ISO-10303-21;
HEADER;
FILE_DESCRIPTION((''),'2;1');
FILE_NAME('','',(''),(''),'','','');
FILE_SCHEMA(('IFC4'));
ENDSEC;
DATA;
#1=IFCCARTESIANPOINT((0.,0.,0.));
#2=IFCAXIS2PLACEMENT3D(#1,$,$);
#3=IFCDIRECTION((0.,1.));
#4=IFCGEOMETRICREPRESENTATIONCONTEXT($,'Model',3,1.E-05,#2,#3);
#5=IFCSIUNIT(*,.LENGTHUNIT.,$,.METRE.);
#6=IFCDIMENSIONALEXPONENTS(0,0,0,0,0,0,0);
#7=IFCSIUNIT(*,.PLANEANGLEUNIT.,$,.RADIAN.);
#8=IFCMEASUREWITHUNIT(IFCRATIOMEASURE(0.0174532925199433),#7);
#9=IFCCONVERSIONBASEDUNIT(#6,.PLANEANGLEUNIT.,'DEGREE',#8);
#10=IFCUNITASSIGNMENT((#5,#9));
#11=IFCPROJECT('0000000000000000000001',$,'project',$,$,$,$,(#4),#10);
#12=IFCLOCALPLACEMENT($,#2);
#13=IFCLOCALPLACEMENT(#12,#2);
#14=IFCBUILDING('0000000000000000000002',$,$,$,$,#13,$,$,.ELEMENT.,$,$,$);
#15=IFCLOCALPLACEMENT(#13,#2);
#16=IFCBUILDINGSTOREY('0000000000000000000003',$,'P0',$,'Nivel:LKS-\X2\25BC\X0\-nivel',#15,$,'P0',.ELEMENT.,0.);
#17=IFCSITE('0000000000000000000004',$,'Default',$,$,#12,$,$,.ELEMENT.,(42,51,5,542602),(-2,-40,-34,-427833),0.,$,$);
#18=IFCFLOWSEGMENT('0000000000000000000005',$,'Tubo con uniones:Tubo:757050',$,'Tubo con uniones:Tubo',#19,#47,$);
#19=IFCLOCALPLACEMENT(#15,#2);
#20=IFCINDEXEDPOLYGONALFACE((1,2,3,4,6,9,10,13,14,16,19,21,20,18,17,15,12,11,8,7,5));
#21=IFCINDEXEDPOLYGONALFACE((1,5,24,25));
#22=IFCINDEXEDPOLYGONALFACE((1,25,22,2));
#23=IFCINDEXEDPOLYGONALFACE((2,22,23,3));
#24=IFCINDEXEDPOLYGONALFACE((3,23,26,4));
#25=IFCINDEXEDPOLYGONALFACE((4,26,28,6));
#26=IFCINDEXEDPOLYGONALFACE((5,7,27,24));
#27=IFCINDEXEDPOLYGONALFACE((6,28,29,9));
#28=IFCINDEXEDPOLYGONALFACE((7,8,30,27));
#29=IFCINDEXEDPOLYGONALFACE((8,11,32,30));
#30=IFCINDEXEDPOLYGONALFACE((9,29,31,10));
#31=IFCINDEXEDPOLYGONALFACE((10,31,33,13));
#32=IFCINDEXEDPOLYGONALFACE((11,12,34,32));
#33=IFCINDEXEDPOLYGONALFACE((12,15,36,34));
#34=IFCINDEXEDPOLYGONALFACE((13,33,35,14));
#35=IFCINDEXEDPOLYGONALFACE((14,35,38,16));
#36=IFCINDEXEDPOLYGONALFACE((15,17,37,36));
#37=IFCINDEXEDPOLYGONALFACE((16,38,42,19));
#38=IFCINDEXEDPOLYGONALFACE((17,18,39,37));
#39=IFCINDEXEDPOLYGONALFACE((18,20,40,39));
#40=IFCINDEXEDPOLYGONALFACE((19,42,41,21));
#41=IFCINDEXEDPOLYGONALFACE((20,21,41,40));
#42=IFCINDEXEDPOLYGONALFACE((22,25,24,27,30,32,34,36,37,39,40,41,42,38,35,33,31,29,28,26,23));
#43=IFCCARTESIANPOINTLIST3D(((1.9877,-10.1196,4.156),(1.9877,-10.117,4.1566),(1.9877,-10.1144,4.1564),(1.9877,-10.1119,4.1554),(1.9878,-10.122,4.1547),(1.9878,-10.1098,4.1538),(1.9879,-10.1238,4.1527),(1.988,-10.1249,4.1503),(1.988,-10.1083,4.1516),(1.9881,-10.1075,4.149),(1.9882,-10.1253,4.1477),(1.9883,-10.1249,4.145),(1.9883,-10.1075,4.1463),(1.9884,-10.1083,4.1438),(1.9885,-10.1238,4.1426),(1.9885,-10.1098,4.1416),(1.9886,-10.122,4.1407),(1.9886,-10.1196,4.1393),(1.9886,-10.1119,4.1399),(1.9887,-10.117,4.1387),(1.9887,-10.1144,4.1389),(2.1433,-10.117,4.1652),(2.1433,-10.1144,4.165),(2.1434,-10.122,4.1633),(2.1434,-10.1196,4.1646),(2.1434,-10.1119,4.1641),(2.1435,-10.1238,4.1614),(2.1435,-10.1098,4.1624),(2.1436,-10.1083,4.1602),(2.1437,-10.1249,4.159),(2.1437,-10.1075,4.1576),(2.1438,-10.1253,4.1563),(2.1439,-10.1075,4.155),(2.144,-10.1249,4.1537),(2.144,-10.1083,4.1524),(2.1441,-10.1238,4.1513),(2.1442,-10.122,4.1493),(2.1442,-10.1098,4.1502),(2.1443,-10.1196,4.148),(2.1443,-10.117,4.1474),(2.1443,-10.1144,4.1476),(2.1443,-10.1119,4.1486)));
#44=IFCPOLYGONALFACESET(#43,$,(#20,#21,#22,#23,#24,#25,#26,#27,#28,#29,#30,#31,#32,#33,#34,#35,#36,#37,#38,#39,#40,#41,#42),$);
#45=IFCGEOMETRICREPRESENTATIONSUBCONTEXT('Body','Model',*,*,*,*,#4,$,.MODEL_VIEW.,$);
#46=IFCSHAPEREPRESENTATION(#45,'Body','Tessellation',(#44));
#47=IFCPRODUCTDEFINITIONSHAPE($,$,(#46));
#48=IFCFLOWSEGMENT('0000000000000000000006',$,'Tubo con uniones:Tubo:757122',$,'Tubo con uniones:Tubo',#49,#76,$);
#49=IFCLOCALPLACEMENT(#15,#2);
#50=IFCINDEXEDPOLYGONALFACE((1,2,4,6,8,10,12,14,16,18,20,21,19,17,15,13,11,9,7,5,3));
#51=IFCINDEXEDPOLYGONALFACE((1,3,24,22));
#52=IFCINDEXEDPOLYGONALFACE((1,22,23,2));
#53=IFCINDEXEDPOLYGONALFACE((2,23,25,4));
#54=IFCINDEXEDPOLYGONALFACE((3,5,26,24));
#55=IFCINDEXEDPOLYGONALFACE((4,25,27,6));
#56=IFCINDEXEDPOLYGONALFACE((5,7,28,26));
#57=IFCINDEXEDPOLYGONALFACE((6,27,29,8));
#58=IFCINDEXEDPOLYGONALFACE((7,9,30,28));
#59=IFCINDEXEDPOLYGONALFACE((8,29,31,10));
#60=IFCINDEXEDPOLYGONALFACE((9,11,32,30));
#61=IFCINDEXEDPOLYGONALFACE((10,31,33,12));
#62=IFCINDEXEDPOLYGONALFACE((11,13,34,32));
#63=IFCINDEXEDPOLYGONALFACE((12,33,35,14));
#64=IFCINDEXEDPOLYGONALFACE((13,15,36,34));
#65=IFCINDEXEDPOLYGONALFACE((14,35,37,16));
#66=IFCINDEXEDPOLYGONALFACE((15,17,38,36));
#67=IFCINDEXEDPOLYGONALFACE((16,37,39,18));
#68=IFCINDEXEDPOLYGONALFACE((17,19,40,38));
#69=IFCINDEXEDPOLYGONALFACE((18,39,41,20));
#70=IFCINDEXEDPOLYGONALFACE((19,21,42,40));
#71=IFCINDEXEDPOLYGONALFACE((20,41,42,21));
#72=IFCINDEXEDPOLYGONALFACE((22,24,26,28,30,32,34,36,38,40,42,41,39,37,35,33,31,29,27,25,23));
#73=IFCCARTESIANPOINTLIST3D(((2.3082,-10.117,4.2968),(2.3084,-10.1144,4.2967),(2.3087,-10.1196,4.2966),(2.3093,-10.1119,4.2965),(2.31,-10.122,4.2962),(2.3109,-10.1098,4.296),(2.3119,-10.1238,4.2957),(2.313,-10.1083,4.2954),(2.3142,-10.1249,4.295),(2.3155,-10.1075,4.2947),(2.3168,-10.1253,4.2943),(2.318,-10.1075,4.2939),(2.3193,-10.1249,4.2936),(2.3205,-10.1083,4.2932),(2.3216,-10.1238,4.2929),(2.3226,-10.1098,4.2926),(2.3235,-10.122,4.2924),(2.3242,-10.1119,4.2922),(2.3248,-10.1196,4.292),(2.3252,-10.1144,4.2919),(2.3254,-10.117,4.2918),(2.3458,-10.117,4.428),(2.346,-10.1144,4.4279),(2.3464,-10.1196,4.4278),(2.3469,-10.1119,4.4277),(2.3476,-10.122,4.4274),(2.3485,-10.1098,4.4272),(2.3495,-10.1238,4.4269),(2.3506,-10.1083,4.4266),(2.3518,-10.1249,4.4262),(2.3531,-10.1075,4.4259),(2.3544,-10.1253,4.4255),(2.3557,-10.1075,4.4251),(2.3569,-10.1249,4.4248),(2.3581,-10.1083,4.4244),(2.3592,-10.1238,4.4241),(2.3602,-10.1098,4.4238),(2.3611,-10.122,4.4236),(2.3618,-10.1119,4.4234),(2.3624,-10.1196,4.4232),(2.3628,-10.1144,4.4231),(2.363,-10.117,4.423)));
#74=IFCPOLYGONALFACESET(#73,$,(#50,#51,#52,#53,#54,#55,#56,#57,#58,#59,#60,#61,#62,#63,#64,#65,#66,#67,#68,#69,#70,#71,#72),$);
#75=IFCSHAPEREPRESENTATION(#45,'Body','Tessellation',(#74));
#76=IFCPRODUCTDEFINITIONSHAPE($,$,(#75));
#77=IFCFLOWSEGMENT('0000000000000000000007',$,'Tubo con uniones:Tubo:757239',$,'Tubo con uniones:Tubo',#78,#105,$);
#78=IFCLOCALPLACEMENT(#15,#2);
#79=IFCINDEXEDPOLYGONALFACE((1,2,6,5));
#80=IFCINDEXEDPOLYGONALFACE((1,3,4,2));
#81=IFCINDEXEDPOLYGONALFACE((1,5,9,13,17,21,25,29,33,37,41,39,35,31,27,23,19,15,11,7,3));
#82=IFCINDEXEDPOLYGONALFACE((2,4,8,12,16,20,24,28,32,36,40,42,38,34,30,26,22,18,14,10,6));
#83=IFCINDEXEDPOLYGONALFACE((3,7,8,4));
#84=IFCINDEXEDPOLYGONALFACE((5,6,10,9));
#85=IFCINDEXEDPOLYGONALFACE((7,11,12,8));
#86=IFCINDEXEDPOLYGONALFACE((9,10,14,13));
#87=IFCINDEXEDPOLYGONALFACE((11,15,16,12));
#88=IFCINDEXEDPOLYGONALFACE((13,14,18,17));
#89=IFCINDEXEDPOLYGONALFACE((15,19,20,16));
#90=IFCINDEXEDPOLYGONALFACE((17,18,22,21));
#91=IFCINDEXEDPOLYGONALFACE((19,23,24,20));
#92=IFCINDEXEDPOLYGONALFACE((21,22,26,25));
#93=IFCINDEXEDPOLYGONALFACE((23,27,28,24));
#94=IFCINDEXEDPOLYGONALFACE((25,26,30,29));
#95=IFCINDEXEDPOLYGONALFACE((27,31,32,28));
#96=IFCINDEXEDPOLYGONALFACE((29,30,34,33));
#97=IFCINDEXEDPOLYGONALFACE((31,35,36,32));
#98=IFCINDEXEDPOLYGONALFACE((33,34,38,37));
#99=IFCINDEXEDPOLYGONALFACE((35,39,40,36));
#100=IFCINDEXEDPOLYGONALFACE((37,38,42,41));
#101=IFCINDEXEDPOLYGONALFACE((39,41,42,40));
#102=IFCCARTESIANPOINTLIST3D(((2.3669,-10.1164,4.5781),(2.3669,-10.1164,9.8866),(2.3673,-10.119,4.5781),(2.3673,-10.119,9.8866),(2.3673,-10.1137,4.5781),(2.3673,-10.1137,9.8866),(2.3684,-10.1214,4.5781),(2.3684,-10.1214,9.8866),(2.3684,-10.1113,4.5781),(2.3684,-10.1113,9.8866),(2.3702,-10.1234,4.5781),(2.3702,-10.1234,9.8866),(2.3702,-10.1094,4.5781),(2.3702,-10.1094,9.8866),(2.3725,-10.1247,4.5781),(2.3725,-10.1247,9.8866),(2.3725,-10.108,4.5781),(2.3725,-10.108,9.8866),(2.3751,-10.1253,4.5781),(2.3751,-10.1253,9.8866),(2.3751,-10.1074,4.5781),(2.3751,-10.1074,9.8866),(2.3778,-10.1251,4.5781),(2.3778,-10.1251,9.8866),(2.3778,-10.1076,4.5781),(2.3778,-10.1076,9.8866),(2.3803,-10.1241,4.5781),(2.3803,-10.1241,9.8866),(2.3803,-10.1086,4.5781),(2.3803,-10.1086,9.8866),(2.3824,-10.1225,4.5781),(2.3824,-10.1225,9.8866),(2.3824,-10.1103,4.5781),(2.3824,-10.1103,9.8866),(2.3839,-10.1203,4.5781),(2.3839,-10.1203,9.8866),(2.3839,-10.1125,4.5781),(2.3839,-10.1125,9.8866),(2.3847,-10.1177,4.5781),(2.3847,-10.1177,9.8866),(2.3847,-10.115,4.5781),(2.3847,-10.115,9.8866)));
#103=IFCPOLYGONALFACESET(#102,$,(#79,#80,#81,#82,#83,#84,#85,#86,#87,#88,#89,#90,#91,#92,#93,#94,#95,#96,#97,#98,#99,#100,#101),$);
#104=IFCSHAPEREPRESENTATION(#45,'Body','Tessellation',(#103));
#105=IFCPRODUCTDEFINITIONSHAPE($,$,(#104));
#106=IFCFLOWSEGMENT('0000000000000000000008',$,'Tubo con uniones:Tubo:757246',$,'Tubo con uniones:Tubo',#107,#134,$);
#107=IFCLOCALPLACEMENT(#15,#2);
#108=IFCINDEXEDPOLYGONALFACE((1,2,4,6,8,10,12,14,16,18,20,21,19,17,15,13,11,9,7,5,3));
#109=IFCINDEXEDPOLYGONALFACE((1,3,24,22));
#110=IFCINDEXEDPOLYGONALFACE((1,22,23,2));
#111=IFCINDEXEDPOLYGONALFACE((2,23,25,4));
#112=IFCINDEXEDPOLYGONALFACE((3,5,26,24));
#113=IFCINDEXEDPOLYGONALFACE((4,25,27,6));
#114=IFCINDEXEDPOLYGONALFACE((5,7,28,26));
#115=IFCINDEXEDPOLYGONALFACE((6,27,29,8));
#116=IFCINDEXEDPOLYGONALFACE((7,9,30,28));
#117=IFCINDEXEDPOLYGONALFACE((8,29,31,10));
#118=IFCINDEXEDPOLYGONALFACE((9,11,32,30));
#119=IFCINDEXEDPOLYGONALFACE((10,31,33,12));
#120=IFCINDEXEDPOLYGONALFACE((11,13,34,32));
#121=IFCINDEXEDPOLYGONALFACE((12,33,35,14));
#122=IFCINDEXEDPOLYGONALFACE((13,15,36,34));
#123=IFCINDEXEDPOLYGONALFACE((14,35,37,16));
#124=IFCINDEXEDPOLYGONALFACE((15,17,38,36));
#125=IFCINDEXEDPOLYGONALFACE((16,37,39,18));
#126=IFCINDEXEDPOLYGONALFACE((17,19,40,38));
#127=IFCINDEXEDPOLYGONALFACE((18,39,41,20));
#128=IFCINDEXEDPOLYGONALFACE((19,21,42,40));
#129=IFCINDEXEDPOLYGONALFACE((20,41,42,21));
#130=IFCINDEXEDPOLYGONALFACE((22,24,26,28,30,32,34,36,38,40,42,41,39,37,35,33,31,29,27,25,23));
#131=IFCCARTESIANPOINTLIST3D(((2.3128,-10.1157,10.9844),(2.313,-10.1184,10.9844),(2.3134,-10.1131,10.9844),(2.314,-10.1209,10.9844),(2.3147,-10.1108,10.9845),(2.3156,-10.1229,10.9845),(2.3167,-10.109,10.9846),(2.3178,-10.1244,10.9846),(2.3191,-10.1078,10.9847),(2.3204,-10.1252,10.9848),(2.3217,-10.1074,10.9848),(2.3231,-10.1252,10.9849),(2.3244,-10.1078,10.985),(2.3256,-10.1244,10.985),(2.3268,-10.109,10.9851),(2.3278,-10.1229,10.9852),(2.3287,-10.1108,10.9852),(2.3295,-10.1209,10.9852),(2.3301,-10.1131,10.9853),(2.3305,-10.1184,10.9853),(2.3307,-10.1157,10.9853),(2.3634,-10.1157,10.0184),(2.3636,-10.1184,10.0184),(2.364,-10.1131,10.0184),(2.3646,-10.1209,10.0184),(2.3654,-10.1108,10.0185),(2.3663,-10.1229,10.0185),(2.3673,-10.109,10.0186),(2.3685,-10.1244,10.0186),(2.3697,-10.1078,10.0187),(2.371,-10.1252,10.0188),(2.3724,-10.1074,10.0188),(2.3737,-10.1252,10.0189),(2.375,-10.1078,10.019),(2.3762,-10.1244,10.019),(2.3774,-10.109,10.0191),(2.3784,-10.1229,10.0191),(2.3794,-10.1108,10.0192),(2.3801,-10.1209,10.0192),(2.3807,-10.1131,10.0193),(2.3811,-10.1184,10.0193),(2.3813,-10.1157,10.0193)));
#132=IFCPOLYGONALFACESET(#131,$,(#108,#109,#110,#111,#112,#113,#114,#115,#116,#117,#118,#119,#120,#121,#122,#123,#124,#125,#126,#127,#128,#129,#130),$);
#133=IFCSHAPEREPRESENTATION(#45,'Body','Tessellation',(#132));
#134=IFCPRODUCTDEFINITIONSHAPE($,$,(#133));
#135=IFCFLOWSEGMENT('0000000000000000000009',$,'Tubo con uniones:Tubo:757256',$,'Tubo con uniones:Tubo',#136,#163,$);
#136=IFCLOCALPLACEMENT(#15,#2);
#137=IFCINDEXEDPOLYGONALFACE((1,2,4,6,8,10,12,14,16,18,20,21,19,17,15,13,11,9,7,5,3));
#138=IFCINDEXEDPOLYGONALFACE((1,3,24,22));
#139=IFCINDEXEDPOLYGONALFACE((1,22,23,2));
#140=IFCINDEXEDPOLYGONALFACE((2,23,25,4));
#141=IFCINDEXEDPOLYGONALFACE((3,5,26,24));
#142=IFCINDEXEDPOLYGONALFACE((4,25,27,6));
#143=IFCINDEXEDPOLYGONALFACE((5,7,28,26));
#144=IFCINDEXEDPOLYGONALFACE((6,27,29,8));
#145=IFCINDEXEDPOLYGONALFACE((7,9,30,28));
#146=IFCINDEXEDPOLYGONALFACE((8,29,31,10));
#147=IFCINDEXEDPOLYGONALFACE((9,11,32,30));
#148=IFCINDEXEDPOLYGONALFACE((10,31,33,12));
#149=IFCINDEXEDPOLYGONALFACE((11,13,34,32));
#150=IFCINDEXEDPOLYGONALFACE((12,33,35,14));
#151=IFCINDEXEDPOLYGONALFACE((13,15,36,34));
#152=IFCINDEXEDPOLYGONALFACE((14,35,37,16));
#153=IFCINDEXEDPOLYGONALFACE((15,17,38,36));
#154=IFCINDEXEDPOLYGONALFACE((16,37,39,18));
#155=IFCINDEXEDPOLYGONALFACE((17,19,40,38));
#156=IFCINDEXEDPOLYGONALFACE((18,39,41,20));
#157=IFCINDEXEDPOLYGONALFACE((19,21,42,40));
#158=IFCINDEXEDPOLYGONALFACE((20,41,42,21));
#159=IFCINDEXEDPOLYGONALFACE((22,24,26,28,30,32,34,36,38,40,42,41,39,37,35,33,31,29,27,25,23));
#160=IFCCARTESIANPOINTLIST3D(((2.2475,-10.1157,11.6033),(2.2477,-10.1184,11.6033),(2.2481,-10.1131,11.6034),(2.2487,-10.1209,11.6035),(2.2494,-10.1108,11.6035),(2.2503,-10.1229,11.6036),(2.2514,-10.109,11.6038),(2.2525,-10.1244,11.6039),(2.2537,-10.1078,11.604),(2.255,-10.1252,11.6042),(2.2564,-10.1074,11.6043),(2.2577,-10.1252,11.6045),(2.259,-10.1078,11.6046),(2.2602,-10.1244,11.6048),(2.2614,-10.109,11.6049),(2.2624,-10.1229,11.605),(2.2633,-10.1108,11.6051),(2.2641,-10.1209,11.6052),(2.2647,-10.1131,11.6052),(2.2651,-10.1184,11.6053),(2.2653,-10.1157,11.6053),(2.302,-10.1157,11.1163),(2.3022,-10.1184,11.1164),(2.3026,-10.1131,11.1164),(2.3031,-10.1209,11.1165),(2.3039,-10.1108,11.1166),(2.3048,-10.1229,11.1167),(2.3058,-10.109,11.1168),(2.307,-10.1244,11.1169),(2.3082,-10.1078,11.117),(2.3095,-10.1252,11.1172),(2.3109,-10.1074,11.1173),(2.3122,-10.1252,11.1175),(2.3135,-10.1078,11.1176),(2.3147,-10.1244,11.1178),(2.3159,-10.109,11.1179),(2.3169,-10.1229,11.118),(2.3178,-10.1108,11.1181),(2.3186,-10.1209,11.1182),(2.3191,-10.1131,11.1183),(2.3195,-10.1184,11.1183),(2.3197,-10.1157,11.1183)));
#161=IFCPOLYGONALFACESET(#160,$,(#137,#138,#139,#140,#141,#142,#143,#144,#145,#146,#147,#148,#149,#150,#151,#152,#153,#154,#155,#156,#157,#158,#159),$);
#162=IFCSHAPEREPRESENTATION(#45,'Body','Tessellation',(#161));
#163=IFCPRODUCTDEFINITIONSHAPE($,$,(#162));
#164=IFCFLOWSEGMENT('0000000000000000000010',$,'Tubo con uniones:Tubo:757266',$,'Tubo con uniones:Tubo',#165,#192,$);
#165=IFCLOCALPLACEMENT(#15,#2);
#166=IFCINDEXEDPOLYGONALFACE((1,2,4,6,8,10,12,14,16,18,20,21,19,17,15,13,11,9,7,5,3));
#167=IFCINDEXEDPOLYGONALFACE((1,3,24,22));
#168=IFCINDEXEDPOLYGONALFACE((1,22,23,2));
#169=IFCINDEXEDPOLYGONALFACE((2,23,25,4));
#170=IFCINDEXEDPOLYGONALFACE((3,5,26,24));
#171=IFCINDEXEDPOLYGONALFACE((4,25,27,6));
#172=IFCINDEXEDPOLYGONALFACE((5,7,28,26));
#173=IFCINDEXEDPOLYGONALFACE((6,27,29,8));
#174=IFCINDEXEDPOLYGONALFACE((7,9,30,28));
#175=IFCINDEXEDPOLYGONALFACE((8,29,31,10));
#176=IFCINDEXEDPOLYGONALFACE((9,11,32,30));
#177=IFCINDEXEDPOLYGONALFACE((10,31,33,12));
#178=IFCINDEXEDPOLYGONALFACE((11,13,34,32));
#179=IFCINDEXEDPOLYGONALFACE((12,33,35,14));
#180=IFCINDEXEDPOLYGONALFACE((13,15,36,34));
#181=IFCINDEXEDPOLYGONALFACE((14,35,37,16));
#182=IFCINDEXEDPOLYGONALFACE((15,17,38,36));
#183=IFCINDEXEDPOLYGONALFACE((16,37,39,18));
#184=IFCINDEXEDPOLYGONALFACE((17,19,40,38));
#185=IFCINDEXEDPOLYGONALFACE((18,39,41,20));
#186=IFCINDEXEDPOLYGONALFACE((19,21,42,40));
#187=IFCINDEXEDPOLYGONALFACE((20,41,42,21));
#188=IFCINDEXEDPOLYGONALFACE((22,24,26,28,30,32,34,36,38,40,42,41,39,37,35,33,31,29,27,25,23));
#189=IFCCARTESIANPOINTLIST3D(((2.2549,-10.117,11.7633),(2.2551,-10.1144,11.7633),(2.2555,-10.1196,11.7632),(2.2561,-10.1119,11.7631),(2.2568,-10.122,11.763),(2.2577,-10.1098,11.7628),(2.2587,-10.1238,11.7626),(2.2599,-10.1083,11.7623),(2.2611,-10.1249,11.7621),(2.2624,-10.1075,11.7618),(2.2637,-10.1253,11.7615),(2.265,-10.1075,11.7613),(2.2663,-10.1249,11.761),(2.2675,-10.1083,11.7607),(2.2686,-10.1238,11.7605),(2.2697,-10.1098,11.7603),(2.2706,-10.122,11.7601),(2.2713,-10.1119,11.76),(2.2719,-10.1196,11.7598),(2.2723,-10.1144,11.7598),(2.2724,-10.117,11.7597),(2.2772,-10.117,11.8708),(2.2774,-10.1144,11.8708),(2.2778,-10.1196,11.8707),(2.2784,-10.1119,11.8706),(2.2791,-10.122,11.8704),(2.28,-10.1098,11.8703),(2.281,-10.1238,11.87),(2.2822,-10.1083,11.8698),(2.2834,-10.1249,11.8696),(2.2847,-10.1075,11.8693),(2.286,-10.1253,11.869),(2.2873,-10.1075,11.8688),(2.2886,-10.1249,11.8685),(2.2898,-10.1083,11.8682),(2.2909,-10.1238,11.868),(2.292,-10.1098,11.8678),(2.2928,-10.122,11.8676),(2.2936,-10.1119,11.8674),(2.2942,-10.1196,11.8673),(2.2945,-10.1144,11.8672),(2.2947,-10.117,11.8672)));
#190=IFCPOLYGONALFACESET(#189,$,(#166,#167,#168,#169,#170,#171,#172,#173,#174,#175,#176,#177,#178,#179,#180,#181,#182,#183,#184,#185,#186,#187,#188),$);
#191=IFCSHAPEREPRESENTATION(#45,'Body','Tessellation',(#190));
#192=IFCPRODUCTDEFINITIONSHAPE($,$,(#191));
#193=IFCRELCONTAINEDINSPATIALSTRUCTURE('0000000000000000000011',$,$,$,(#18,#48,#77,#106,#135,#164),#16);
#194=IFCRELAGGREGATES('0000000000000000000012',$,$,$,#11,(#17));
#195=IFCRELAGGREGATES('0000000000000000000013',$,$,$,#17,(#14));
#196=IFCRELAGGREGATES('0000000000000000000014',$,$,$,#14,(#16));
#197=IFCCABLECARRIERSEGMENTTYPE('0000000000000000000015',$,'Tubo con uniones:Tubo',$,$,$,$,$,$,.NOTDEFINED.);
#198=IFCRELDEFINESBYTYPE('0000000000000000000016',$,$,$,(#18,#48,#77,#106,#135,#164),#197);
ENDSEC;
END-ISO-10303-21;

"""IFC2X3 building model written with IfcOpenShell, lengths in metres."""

from ifc_helpers import new_model, entity, si_unit, converted_unit, direction, frame, frame_2d, origin, origin_2d_with_axis, place, context, subcontext, project, spatial, circle, extrude, type_object, element, save


model = new_model("IFC2X3")

# Units and contexts
model_context = context("Model", 3, precision=1e-05, world=origin(), true_north=direction((0.0, 1.0)))
body_context = subcontext(model_context, "Body", "Model", "MODEL_VIEW")
ifc_project = project(units=[si_unit("LENGTHUNIT", "METRE"), converted_unit("PLANEANGLEUNIT", "DEGREE", entity("IfcRatioMeasure", 0.0174532925199433), si_unit("PLANEANGLEUNIT", "RADIAN"), dimensions=[0, 0, 0, 0, 0, 0, 0])], contexts=[model_context])

# Site, building, storey
site_placement = place(None, origin())
site = spatial("IfcSite", under=ifc_project, at=site_placement, Name="Default", CompositionType="ELEMENT", RefLatitude=(42, 51, 5, 542602), RefLongitude=(-2, -40, -34, -427833), RefElevation=0.0)
building_placement = place(site_placement, origin())
building = spatial("IfcBuilding", under=site, at=building_placement, CompositionType="ELEMENT")
storey_placement = place(building_placement, origin())
storey = spatial("IfcBuildingStorey", under=building, at=storey_placement, Name="P0", ObjectType="Nivel:LKS-▼-nivel", LongName="P0", CompositionType="ELEMENT", Elevation=0.0)

# Flow segments
cable_carrier_segment_type = type_object("IfcCableCarrierSegmentType", Name="Tubo con uniones:Tubo", PredefinedType="NOTDEFINED")
flow_segment_1_placement = place(storey_placement, origin())
element("IfcFlowSegment", 1, at=flow_segment_1_placement, inside=storey, type_object=cable_carrier_segment_type, Name="Tubo con uniones:Tubo:757050", ObjectType="Tubo con uniones:Tubo", context=body_context, shape_type="SweptSolid", body=[
    extrude(circle(Radius=0.009, at=origin_2d_with_axis()), frame((1.9882, -10.1164, 4.1477), z_axis=(0.998462, 0.0, 0.055441), x_axis=(0.0, -1.0, 0.0)), (0.0, 0.0, 1.0), 0.1559),
])
flow_segment_2_placement = place(storey_placement, origin())
element("IfcFlowSegment", 2, at=flow_segment_2_placement, inside=storey, type_object=cable_carrier_segment_type, Name="Tubo con uniones:Tubo:757122", ObjectType="Tubo con uniones:Tubo", context=body_context, shape_type="SweptSolid", body=[
    extrude(circle(Radius=0.009, at=origin_2d_with_axis()), frame((2.3168, -10.1164, 4.2943), z_axis=(0.275637, 0.0, 0.961262), x_axis=(0.0, -1.0, 0.0)), (0.0, 0.0, 1.0), 0.1365),
])
flow_segment_3_placement = place(storey_placement, origin())
element("IfcFlowSegment", 3, at=flow_segment_3_placement, inside=storey, type_object=cable_carrier_segment_type, Name="Tubo con uniones:Tubo:757239", ObjectType="Tubo con uniones:Tubo", context=body_context, shape_type="SweptSolid", body=[
    extrude(circle(Radius=0.009, at=origin_2d_with_axis()), frame((2.3758, -10.1164, 4.5781), z_axis=(0.0, 0.0, 1.0), x_axis=(-1.0, 0.0, 0.0)), (0.0, 0.0, 1.0), 5.3085),
])
flow_segment_4_placement = place(storey_placement, origin())
element("IfcFlowSegment", 4, at=flow_segment_4_placement, inside=storey, type_object=cable_carrier_segment_type, Name="Tubo con uniones:Tubo:757246", ObjectType="Tubo con uniones:Tubo", context=body_context, shape_type="SweptSolid", body=[
    extrude(circle(Radius=0.009, at=origin_2d_with_axis()), frame((2.3217, -10.1164, 10.9848), z_axis=(0.052336, 0.0, -0.99863), x_axis=(0.0, 1.0, 0.0)), (0.0, 0.0, 1.0), 0.9673),
])
flow_segment_5_placement = place(storey_placement, origin())
element("IfcFlowSegment", 5, at=flow_segment_5_placement, inside=storey, type_object=cable_carrier_segment_type, Name="Tubo con uniones:Tubo:757256", ObjectType="Tubo con uniones:Tubo", context=body_context, shape_type="SweptSolid", body=[
    extrude(circle(Radius=0.009, at=frame_2d((0.0, 0.0), x_axis=(1.0, 0.0))), frame((2.2564, -10.1164, 11.6043), z_axis=(0.111187, 0.0, -0.9938), x_axis=(0.0, 1.0, 0.0)), (0.0, 0.0, 1.0), 0.49),
])
flow_segment_6_placement = place(storey_placement, origin())
element("IfcFlowSegment", 6, at=flow_segment_6_placement, inside=storey, type_object=cable_carrier_segment_type, Name="Tubo con uniones:Tubo:757266", ObjectType="Tubo con uniones:Tubo", context=body_context, shape_type="SweptSolid", body=[
    extrude(circle(Radius=0.009, at=origin_2d_with_axis()), frame((2.2637, -10.1164, 11.7615), z_axis=(0.203079, 0.0, 0.979162), x_axis=(0.0, -1.0, 0.0)), (0.0, 0.0, 1.0), 0.1098),
])

save(model, "model.ifc")
